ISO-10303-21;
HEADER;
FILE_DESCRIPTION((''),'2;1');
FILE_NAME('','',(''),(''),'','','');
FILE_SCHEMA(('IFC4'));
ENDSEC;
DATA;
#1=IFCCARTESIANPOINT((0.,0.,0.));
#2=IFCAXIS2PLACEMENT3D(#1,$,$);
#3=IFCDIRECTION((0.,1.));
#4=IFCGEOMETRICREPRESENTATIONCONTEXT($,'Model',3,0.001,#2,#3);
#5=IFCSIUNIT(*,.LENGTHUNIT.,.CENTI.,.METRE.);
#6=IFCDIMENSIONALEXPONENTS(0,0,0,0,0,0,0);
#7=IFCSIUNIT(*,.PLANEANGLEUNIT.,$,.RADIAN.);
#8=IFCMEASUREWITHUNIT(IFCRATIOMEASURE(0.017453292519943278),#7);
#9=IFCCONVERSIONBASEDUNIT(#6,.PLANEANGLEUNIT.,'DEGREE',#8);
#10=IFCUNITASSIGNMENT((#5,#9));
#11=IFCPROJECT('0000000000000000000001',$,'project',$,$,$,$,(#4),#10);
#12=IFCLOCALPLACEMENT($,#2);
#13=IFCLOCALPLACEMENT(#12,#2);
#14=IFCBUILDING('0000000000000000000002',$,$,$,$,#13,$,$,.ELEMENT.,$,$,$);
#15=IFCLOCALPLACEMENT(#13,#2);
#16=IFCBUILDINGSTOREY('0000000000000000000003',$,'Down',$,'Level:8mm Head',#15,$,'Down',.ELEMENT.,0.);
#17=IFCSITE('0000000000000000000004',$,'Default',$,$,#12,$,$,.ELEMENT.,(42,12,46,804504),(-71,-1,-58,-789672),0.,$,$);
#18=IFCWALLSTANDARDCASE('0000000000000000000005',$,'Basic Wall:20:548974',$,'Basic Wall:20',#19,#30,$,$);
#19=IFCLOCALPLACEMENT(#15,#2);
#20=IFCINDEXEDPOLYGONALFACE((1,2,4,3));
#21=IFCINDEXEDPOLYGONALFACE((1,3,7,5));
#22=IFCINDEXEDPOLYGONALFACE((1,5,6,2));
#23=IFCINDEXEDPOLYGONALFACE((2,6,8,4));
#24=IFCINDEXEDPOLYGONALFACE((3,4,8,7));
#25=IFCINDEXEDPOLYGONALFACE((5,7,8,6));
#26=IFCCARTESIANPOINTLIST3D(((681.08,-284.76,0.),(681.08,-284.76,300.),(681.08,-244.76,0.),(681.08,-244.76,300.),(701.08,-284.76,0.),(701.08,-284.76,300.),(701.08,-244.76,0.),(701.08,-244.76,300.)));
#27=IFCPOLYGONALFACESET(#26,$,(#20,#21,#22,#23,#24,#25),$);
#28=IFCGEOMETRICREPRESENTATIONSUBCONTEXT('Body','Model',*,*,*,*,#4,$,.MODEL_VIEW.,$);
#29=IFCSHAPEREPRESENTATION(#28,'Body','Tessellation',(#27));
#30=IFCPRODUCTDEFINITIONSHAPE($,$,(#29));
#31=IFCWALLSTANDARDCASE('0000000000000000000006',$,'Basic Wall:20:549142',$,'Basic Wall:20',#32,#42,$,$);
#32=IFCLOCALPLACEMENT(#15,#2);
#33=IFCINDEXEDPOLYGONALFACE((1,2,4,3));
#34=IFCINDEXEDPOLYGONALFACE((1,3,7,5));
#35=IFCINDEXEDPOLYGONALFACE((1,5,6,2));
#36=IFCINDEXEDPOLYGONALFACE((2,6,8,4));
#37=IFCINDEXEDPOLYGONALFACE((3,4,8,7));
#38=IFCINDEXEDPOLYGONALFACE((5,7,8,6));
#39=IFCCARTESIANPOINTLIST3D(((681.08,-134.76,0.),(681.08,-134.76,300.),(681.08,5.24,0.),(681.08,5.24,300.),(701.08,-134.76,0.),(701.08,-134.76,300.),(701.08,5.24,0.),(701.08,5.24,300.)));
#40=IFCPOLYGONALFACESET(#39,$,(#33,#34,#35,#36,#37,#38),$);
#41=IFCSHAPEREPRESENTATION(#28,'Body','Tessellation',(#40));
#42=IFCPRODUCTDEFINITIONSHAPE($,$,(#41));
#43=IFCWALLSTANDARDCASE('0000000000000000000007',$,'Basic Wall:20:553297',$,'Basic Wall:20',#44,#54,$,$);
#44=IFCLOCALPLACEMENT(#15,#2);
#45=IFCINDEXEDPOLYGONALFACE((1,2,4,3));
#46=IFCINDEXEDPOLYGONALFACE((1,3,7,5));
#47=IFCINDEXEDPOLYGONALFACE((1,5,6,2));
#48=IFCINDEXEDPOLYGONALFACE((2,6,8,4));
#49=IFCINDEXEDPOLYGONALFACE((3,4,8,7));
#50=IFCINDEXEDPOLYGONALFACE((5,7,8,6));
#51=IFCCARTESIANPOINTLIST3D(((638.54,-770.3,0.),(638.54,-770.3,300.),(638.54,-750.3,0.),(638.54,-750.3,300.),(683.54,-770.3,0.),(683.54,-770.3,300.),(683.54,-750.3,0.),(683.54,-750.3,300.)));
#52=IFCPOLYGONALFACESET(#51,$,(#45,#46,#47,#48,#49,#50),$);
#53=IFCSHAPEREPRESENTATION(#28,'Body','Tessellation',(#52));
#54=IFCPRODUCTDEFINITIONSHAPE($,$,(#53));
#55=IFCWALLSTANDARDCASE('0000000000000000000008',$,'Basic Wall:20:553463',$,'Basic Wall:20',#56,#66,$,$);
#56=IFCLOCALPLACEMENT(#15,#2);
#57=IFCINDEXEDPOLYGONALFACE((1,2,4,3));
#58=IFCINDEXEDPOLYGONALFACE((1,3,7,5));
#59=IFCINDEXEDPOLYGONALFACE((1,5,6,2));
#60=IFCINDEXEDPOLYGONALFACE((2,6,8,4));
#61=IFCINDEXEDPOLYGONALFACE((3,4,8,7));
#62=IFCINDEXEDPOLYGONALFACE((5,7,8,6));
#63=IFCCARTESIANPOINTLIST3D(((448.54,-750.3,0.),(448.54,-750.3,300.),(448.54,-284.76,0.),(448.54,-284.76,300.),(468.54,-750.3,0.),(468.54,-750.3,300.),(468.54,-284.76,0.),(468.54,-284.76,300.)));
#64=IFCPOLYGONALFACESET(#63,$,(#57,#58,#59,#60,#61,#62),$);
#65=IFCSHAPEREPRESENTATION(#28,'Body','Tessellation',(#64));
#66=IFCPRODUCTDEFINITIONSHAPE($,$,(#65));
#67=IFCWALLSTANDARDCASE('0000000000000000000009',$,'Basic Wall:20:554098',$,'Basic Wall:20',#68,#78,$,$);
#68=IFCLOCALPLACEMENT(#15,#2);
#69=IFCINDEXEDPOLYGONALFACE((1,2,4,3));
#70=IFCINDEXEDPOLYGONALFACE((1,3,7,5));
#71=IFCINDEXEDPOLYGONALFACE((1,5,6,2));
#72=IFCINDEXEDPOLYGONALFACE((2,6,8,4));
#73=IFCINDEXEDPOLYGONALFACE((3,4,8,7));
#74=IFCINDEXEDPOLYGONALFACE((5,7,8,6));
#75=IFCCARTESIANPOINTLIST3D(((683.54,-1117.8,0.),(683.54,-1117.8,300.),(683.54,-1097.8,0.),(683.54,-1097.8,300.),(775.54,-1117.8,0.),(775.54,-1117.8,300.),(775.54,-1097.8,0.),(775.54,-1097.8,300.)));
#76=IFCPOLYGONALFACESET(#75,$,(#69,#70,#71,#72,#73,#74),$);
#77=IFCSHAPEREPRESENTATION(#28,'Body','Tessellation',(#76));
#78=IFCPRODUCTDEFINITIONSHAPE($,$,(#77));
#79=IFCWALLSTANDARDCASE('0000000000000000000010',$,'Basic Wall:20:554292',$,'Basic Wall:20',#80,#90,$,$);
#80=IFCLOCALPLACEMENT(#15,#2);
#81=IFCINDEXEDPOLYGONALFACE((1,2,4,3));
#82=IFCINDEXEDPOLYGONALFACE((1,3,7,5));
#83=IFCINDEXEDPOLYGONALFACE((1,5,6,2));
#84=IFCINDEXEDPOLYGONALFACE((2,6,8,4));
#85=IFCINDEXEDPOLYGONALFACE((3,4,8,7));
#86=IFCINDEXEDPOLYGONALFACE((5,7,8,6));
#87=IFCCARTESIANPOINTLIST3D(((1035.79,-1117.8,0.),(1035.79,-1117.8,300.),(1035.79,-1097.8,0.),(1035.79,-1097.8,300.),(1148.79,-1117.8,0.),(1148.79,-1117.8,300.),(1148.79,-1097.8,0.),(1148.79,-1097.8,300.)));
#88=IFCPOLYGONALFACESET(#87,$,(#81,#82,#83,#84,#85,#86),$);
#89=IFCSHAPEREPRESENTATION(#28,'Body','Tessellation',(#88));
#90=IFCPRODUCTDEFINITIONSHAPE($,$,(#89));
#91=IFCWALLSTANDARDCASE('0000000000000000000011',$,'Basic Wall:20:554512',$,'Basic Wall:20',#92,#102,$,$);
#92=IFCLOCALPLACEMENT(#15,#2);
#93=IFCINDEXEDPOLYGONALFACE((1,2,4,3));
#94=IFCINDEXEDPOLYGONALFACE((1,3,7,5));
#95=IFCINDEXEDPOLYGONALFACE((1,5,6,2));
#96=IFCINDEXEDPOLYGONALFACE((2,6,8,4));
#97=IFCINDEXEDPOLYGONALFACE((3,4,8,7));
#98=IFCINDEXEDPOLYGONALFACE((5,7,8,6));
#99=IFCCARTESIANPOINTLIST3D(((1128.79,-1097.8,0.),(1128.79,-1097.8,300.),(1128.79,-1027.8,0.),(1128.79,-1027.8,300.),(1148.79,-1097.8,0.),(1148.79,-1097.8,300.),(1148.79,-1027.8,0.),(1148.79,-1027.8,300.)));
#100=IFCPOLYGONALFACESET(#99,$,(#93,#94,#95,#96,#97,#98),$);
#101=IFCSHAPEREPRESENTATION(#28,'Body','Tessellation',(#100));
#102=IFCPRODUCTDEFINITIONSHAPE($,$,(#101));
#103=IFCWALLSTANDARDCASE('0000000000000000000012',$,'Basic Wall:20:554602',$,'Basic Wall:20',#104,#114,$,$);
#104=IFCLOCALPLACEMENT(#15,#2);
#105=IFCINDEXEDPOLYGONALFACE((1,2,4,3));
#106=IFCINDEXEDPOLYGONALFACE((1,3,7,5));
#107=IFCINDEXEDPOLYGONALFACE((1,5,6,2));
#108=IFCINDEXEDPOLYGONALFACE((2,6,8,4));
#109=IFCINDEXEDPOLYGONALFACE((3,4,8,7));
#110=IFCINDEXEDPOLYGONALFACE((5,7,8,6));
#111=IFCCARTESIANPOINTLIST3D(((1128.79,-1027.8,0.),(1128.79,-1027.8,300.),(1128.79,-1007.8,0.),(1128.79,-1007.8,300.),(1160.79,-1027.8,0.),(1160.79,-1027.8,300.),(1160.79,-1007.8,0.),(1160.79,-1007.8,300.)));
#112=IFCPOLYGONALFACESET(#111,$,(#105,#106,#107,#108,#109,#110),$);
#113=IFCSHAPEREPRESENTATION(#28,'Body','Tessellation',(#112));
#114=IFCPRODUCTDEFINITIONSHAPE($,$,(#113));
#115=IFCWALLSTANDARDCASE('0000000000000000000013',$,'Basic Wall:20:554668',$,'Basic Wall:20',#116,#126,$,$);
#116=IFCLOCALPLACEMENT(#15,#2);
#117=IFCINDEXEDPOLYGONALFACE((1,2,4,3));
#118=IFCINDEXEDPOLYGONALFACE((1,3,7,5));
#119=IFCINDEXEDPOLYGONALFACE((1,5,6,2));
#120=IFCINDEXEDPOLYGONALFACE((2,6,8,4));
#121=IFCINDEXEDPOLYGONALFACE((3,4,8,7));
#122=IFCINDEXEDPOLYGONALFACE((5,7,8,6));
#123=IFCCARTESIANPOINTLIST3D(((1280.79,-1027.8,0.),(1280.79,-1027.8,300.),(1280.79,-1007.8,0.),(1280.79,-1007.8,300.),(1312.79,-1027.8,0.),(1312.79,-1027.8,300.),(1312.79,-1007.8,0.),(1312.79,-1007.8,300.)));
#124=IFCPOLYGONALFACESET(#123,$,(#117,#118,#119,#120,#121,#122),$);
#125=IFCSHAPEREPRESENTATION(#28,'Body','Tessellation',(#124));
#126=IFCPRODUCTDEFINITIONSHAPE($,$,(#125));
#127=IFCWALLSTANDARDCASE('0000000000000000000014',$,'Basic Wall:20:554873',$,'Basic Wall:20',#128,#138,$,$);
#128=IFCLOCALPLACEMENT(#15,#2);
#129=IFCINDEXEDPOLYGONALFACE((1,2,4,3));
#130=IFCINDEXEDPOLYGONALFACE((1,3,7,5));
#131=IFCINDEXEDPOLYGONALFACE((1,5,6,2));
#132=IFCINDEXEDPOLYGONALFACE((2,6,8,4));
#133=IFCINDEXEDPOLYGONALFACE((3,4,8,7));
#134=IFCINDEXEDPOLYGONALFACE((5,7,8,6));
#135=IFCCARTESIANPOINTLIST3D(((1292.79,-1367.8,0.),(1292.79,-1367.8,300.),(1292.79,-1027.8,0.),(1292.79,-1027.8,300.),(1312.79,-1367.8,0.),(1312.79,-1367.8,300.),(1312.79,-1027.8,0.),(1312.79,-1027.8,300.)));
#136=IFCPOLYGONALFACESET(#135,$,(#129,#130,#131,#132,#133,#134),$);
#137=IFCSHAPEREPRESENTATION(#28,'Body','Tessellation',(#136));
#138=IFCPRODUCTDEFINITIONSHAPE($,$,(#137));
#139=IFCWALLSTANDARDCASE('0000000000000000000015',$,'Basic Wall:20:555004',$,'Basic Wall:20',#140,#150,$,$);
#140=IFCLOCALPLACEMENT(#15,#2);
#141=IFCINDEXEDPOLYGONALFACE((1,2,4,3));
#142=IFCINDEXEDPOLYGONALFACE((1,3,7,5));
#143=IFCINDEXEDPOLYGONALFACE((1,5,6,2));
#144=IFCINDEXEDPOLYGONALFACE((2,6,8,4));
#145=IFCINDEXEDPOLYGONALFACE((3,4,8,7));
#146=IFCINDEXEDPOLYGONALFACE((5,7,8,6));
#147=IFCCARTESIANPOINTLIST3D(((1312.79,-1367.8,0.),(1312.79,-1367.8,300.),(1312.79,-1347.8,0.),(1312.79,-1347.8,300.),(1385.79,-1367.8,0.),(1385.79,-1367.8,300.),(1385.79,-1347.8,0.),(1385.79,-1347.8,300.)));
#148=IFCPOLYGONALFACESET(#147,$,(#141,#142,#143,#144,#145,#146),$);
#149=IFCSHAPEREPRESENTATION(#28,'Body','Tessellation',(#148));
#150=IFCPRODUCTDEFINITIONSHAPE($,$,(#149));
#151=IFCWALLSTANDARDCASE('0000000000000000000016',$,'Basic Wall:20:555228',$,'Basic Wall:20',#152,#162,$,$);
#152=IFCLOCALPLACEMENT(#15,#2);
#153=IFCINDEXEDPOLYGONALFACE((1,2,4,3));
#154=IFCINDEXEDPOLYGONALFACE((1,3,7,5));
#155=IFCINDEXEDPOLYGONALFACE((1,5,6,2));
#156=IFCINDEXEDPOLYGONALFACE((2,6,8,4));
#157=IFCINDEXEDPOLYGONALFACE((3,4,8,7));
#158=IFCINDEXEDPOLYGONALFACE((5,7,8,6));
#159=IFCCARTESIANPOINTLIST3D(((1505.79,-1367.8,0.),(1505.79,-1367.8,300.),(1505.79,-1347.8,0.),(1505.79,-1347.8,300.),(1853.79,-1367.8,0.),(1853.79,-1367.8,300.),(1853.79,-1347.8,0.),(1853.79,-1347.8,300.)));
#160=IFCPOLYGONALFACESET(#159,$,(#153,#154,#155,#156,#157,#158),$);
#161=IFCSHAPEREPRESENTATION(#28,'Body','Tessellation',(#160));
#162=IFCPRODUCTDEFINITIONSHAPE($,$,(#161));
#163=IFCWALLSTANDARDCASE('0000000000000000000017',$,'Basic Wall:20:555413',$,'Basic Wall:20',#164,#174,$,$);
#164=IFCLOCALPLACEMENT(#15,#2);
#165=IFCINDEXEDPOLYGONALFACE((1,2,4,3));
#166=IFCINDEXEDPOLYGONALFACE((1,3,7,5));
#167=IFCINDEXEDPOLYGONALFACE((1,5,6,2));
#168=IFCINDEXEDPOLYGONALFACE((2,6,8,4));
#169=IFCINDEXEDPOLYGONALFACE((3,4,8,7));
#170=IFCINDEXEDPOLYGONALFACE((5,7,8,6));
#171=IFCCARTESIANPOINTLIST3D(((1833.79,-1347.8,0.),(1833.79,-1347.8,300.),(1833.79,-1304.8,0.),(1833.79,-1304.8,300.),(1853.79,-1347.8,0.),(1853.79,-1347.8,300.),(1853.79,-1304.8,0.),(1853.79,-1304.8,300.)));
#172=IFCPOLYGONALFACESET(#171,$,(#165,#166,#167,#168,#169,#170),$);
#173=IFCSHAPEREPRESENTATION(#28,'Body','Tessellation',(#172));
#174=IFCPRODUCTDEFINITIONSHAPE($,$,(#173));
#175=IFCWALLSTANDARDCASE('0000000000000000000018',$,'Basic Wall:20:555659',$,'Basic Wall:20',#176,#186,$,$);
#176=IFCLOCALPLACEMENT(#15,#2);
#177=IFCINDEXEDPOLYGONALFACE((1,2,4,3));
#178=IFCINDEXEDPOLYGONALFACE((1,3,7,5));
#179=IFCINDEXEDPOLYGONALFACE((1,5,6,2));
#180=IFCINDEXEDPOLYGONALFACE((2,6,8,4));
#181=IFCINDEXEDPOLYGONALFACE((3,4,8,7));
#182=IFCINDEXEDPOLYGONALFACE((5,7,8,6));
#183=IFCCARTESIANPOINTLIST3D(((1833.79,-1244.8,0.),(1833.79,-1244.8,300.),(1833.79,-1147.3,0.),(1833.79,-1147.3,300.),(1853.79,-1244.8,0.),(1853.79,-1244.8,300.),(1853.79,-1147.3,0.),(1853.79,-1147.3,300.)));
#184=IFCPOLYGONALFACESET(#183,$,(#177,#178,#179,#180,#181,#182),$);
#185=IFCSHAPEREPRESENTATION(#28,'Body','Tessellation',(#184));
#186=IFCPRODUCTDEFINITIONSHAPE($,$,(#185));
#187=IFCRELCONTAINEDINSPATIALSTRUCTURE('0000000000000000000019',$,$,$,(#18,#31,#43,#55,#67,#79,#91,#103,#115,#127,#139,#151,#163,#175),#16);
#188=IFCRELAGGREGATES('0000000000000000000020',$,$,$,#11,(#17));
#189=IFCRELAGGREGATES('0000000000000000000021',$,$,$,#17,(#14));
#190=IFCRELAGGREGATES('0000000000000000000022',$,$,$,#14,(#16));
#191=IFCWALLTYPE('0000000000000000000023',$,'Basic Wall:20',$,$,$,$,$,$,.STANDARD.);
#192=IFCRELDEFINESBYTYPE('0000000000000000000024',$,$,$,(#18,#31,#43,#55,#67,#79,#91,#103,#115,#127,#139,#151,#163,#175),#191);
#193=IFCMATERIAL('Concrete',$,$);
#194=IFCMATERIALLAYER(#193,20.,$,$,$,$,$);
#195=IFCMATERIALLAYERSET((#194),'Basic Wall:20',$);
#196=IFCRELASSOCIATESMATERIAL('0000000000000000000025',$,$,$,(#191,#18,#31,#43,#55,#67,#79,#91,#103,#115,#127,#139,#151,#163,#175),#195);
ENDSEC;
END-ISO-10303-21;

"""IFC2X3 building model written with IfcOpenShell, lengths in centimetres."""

from ifc_helpers import new_model, entity, si_unit, converted_unit, direction, frame, frame_2d, origin, place, context, subcontext, project, spatial, rectangle, extrude, material, layer, layer_set, layer_usage, type_object, element, save


model = new_model("IFC2X3")

# Units and contexts
model_context = context("Model", 3, precision=0.001, world=origin(), true_north=direction((0.0, 1.0)))
body_context = subcontext(model_context, "Body", "Model", "MODEL_VIEW")
ifc_project = project(units=[si_unit("LENGTHUNIT", "METRE", prefix="CENTI"), converted_unit("PLANEANGLEUNIT", "DEGREE", entity("IfcRatioMeasure", 0.017453292519943278), si_unit("PLANEANGLEUNIT", "RADIAN"), dimensions=[0, 0, 0, 0, 0, 0, 0])], contexts=[model_context])

# Site, building, storey
site_placement = place(None, origin())
site = spatial("IfcSite", under=ifc_project, at=site_placement, Name="Default", CompositionType="ELEMENT", RefLatitude=(42, 12, 46, 804504), RefLongitude=(-71, -1, -58, -789672), RefElevation=0.0)
building_placement = place(site_placement, origin())
building = spatial("IfcBuilding", under=site, at=building_placement, CompositionType="ELEMENT")
storey_placement = place(building_placement, origin())
storey = spatial("IfcBuildingStorey", under=building, at=storey_placement, Name="Down", ObjectType="Level:8mm Head", LongName="Down", CompositionType="ELEMENT", Elevation=0.0)

# Walls
ifc_material = material(Name="Concrete")
ifc_layer_1 = layer(ifc_material, 20.0)
ifc_layer_set_1 = layer_set([ifc_layer_1], Name="Basic Wall:20")
ifc_layer_usage_1 = layer_usage(ifc_layer_set_1, "AXIS2", "POSITIVE", -10.0)
wall_type_1 = type_object("IfcWallType", Name="Basic Wall:20", PredefinedType="STANDARD", material=ifc_layer_set_1)
wall_1_placement = place(storey_placement, frame((691.08, -284.76, 0.0), z_axis=(0.0, 0.0, 1.0), x_axis=(0.0, 1.0, 0.0)))
element("IfcWallStandardCase", 1, at=wall_1_placement, inside=storey, type_object=wall_type_1, material=ifc_layer_usage_1, Name="Basic Wall:20:548974", ObjectType="Basic Wall:20", context=body_context, shape_type="SweptSolid", body=[
    extrude(rectangle(XDim=40.0, YDim=20.0, at=frame_2d((20.0, 0.0), x_axis=(-1.0, 0.0))), origin(), (0.0, 0.0, 1.0), 300.0),
])
ifc_layer_usage_2 = layer_usage(ifc_layer_set_1, "AXIS2", "NEGATIVE", 10.0)
wall_2_placement = place(storey_placement, frame((691.08, 5.24, 0.0), z_axis=(0.0, 0.0, 1.0), x_axis=(0.0, -1.0, 0.0)))
element("IfcWallStandardCase", 2, at=wall_2_placement, inside=storey, type_object=wall_type_1, material=ifc_layer_usage_2, Name="Basic Wall:20:549142", ObjectType="Basic Wall:20", context=body_context, shape_type="SweptSolid", body=[
    extrude(rectangle(XDim=140.0, YDim=20.0, at=frame_2d((70.0, 0.0), x_axis=(-1.0, 0.0))), origin(), (0.0, 0.0, 1.0), 300.0),
])
ifc_layer_usage_3 = layer_usage(ifc_layer_set_1, "AXIS2", "NEGATIVE", 10.0)
wall_3_placement = place(storey_placement, frame((638.54, -760.3, 0.0)))
element("IfcWallStandardCase", 3, at=wall_3_placement, inside=storey, type_object=wall_type_1, material=ifc_layer_usage_3, Name="Basic Wall:20:553297", ObjectType="Basic Wall:20", context=body_context, shape_type="SweptSolid", body=[
    extrude(rectangle(XDim=45.0, YDim=20.0, at=frame_2d((22.5, 0.0), x_axis=(-1.0, 0.0))), origin(), (0.0, 0.0, 1.0), 300.0),
])
ifc_layer_usage_4 = layer_usage(ifc_layer_set_1, "AXIS2", "POSITIVE", -10.0)
wall_4_placement = place(storey_placement, frame((458.54, -750.3, 0.0), z_axis=(0.0, 0.0, 1.0), x_axis=(0.0, 1.0, 0.0)))
element("IfcWallStandardCase", 4, at=wall_4_placement, inside=storey, type_object=wall_type_1, material=ifc_layer_usage_4, Name="Basic Wall:20:553463", ObjectType="Basic Wall:20", context=body_context, shape_type="SweptSolid", body=[
    extrude(rectangle(XDim=465.53, YDim=20.0, at=frame_2d((232.77, 0.0), x_axis=(-1.0, 0.0))), origin(), (0.0, 0.0, 1.0), 300.0),
])
ifc_layer_usage_5 = layer_usage(ifc_layer_set_1, "AXIS2", "POSITIVE", -10.0)
wall_5_placement = place(storey_placement, frame((683.54, -1107.8, 0.0)))
element("IfcWallStandardCase", 5, at=wall_5_placement, inside=storey, type_object=wall_type_1, material=ifc_layer_usage_5, Name="Basic Wall:20:554098", ObjectType="Basic Wall:20", context=body_context, shape_type="SweptSolid", body=[
    extrude(rectangle(XDim=92.0, YDim=20.0, at=frame_2d((46.0, 0.0), x_axis=(-1.0, 0.0))), origin(), (0.0, 0.0, 1.0), 300.0),
])
ifc_layer_usage_6 = layer_usage(ifc_layer_set_1, "AXIS2", "POSITIVE", -10.0)
wall_6_placement = place(storey_placement, frame((1035.79, -1107.8, 0.0)))
element("IfcWallStandardCase", 6, at=wall_6_placement, inside=storey, type_object=wall_type_1, material=ifc_layer_usage_6, Name="Basic Wall:20:554292", ObjectType="Basic Wall:20", context=body_context, shape_type="SweptSolid", body=[
    extrude(rectangle(XDim=113.0, YDim=20.0, at=frame_2d((56.5, 0.0), x_axis=(-1.0, 0.0))), origin(), (0.0, 0.0, 1.0), 300.0),
])
ifc_layer_usage_7 = layer_usage(ifc_layer_set_1, "AXIS2", "POSITIVE", -10.0)
wall_7_placement = place(storey_placement, frame((1138.79, -1097.8, 0.0), z_axis=(0.0, 0.0, 1.0), x_axis=(0.0, 1.0, 0.0)))
element("IfcWallStandardCase", 7, at=wall_7_placement, inside=storey, type_object=wall_type_1, material=ifc_layer_usage_7, Name="Basic Wall:20:554512", ObjectType="Basic Wall:20", context=body_context, shape_type="SweptSolid", body=[
    extrude(rectangle(XDim=70.0, YDim=20.0, at=frame_2d((35.0, 0.0), x_axis=(-1.0, 0.0))), origin(), (0.0, 0.0, 1.0), 300.0),
])
ifc_layer_usage_8 = layer_usage(ifc_layer_set_1, "AXIS2", "NEGATIVE", 10.0)
wall_8_placement = place(storey_placement, frame((1128.79, -1017.8, 0.0)))
element("IfcWallStandardCase", 8, at=wall_8_placement, inside=storey, type_object=wall_type_1, material=ifc_layer_usage_8, Name="Basic Wall:20:554602", ObjectType="Basic Wall:20", context=body_context, shape_type="SweptSolid", body=[
    extrude(rectangle(XDim=32.0, YDim=20.0, at=frame_2d((16.0, 0.0), x_axis=(-1.0, 0.0))), origin(), (0.0, 0.0, 1.0), 300.0),
])
ifc_layer_usage_9 = layer_usage(ifc_layer_set_1, "AXIS2", "NEGATIVE", 10.0)
wall_9_placement = place(storey_placement, frame((1280.79, -1017.8, 0.0)))
element("IfcWallStandardCase", 9, at=wall_9_placement, inside=storey, type_object=wall_type_1, material=ifc_layer_usage_9, Name="Basic Wall:20:554668", ObjectType="Basic Wall:20", context=body_context, shape_type="SweptSolid", body=[
    extrude(rectangle(XDim=32.0, YDim=20.0, at=frame_2d((16.0, 0.0), x_axis=(-1.0, 0.0))), origin(), (0.0, 0.0, 1.0), 300.0),
])
ifc_layer_usage_10 = layer_usage(ifc_layer_set_1, "AXIS2", "NEGATIVE", 10.0)
wall_10_placement = place(storey_placement, frame((1302.79, -1027.8, 0.0), z_axis=(0.0, 0.0, 1.0), x_axis=(0.0, -1.0, 0.0)))
element("IfcWallStandardCase", 10, at=wall_10_placement, inside=storey, type_object=wall_type_1, material=ifc_layer_usage_10, Name="Basic Wall:20:554873", ObjectType="Basic Wall:20", context=body_context, shape_type="SweptSolid", body=[
    extrude(rectangle(XDim=340.0, YDim=20.0, at=frame_2d((170.0, 0.0), x_axis=(-1.0, 0.0))), origin(), (0.0, 0.0, 1.0), 300.0),
])
ifc_layer_usage_11 = layer_usage(ifc_layer_set_1, "AXIS2", "POSITIVE", -10.0)
wall_11_placement = place(storey_placement, frame((1312.79, -1357.8, 0.0)))
element("IfcWallStandardCase", 11, at=wall_11_placement, inside=storey, type_object=wall_type_1, material=ifc_layer_usage_11, Name="Basic Wall:20:555004", ObjectType="Basic Wall:20", context=body_context, shape_type="SweptSolid", body=[
    extrude(rectangle(XDim=73.0, YDim=20.0, at=frame_2d((36.5, 0.0), x_axis=(-1.0, 0.0))), origin(), (0.0, 0.0, 1.0), 300.0),
])
ifc_layer_usage_12 = layer_usage(ifc_layer_set_1, "AXIS2", "POSITIVE", -10.0)
wall_12_placement = place(storey_placement, frame((1505.79, -1357.8, 0.0)))
element("IfcWallStandardCase", 12, at=wall_12_placement, inside=storey, type_object=wall_type_1, material=ifc_layer_usage_12, Name="Basic Wall:20:555228", ObjectType="Basic Wall:20", context=body_context, shape_type="SweptSolid", body=[
    extrude(rectangle(XDim=348.0, YDim=20.0, at=frame_2d((174.0, 0.0), x_axis=(-1.0, 0.0))), origin(), (0.0, 0.0, 1.0), 300.0),
])
ifc_layer_usage_13 = layer_usage(ifc_layer_set_1, "AXIS2", "POSITIVE", -10.0)
wall_13_placement = place(storey_placement, frame((1843.79, -1347.8, 0.0), z_axis=(0.0, 0.0, 1.0), x_axis=(0.0, 1.0, 0.0)))
element("IfcWallStandardCase", 13, at=wall_13_placement, inside=storey, type_object=wall_type_1, material=ifc_layer_usage_13, Name="Basic Wall:20:555413", ObjectType="Basic Wall:20", context=body_context, shape_type="SweptSolid", body=[
    extrude(rectangle(XDim=43.0, YDim=20.0, at=frame_2d((21.5, 0.0), x_axis=(-1.0, 0.0))), origin(), (0.0, 0.0, 1.0), 300.0),
])
ifc_layer_usage_14 = layer_usage(ifc_layer_set_1, "AXIS2", "POSITIVE", -10.0)
wall_14_placement = place(storey_placement, frame((1843.79, -1244.8, 0.0), z_axis=(0.0, 0.0, 1.0), x_axis=(0.0, 1.0, 0.0)))
element("IfcWallStandardCase", 14, at=wall_14_placement, inside=storey, type_object=wall_type_1, material=ifc_layer_usage_14, Name="Basic Wall:20:555659", ObjectType="Basic Wall:20", context=body_context, shape_type="SweptSolid", body=[
    extrude(rectangle(XDim=97.5, YDim=20.0, at=frame_2d((48.75, 0.0), x_axis=(-1.0, 0.0))), origin(), (0.0, 0.0, 1.0), 300.0),
])

save(model, "model.ifc")
